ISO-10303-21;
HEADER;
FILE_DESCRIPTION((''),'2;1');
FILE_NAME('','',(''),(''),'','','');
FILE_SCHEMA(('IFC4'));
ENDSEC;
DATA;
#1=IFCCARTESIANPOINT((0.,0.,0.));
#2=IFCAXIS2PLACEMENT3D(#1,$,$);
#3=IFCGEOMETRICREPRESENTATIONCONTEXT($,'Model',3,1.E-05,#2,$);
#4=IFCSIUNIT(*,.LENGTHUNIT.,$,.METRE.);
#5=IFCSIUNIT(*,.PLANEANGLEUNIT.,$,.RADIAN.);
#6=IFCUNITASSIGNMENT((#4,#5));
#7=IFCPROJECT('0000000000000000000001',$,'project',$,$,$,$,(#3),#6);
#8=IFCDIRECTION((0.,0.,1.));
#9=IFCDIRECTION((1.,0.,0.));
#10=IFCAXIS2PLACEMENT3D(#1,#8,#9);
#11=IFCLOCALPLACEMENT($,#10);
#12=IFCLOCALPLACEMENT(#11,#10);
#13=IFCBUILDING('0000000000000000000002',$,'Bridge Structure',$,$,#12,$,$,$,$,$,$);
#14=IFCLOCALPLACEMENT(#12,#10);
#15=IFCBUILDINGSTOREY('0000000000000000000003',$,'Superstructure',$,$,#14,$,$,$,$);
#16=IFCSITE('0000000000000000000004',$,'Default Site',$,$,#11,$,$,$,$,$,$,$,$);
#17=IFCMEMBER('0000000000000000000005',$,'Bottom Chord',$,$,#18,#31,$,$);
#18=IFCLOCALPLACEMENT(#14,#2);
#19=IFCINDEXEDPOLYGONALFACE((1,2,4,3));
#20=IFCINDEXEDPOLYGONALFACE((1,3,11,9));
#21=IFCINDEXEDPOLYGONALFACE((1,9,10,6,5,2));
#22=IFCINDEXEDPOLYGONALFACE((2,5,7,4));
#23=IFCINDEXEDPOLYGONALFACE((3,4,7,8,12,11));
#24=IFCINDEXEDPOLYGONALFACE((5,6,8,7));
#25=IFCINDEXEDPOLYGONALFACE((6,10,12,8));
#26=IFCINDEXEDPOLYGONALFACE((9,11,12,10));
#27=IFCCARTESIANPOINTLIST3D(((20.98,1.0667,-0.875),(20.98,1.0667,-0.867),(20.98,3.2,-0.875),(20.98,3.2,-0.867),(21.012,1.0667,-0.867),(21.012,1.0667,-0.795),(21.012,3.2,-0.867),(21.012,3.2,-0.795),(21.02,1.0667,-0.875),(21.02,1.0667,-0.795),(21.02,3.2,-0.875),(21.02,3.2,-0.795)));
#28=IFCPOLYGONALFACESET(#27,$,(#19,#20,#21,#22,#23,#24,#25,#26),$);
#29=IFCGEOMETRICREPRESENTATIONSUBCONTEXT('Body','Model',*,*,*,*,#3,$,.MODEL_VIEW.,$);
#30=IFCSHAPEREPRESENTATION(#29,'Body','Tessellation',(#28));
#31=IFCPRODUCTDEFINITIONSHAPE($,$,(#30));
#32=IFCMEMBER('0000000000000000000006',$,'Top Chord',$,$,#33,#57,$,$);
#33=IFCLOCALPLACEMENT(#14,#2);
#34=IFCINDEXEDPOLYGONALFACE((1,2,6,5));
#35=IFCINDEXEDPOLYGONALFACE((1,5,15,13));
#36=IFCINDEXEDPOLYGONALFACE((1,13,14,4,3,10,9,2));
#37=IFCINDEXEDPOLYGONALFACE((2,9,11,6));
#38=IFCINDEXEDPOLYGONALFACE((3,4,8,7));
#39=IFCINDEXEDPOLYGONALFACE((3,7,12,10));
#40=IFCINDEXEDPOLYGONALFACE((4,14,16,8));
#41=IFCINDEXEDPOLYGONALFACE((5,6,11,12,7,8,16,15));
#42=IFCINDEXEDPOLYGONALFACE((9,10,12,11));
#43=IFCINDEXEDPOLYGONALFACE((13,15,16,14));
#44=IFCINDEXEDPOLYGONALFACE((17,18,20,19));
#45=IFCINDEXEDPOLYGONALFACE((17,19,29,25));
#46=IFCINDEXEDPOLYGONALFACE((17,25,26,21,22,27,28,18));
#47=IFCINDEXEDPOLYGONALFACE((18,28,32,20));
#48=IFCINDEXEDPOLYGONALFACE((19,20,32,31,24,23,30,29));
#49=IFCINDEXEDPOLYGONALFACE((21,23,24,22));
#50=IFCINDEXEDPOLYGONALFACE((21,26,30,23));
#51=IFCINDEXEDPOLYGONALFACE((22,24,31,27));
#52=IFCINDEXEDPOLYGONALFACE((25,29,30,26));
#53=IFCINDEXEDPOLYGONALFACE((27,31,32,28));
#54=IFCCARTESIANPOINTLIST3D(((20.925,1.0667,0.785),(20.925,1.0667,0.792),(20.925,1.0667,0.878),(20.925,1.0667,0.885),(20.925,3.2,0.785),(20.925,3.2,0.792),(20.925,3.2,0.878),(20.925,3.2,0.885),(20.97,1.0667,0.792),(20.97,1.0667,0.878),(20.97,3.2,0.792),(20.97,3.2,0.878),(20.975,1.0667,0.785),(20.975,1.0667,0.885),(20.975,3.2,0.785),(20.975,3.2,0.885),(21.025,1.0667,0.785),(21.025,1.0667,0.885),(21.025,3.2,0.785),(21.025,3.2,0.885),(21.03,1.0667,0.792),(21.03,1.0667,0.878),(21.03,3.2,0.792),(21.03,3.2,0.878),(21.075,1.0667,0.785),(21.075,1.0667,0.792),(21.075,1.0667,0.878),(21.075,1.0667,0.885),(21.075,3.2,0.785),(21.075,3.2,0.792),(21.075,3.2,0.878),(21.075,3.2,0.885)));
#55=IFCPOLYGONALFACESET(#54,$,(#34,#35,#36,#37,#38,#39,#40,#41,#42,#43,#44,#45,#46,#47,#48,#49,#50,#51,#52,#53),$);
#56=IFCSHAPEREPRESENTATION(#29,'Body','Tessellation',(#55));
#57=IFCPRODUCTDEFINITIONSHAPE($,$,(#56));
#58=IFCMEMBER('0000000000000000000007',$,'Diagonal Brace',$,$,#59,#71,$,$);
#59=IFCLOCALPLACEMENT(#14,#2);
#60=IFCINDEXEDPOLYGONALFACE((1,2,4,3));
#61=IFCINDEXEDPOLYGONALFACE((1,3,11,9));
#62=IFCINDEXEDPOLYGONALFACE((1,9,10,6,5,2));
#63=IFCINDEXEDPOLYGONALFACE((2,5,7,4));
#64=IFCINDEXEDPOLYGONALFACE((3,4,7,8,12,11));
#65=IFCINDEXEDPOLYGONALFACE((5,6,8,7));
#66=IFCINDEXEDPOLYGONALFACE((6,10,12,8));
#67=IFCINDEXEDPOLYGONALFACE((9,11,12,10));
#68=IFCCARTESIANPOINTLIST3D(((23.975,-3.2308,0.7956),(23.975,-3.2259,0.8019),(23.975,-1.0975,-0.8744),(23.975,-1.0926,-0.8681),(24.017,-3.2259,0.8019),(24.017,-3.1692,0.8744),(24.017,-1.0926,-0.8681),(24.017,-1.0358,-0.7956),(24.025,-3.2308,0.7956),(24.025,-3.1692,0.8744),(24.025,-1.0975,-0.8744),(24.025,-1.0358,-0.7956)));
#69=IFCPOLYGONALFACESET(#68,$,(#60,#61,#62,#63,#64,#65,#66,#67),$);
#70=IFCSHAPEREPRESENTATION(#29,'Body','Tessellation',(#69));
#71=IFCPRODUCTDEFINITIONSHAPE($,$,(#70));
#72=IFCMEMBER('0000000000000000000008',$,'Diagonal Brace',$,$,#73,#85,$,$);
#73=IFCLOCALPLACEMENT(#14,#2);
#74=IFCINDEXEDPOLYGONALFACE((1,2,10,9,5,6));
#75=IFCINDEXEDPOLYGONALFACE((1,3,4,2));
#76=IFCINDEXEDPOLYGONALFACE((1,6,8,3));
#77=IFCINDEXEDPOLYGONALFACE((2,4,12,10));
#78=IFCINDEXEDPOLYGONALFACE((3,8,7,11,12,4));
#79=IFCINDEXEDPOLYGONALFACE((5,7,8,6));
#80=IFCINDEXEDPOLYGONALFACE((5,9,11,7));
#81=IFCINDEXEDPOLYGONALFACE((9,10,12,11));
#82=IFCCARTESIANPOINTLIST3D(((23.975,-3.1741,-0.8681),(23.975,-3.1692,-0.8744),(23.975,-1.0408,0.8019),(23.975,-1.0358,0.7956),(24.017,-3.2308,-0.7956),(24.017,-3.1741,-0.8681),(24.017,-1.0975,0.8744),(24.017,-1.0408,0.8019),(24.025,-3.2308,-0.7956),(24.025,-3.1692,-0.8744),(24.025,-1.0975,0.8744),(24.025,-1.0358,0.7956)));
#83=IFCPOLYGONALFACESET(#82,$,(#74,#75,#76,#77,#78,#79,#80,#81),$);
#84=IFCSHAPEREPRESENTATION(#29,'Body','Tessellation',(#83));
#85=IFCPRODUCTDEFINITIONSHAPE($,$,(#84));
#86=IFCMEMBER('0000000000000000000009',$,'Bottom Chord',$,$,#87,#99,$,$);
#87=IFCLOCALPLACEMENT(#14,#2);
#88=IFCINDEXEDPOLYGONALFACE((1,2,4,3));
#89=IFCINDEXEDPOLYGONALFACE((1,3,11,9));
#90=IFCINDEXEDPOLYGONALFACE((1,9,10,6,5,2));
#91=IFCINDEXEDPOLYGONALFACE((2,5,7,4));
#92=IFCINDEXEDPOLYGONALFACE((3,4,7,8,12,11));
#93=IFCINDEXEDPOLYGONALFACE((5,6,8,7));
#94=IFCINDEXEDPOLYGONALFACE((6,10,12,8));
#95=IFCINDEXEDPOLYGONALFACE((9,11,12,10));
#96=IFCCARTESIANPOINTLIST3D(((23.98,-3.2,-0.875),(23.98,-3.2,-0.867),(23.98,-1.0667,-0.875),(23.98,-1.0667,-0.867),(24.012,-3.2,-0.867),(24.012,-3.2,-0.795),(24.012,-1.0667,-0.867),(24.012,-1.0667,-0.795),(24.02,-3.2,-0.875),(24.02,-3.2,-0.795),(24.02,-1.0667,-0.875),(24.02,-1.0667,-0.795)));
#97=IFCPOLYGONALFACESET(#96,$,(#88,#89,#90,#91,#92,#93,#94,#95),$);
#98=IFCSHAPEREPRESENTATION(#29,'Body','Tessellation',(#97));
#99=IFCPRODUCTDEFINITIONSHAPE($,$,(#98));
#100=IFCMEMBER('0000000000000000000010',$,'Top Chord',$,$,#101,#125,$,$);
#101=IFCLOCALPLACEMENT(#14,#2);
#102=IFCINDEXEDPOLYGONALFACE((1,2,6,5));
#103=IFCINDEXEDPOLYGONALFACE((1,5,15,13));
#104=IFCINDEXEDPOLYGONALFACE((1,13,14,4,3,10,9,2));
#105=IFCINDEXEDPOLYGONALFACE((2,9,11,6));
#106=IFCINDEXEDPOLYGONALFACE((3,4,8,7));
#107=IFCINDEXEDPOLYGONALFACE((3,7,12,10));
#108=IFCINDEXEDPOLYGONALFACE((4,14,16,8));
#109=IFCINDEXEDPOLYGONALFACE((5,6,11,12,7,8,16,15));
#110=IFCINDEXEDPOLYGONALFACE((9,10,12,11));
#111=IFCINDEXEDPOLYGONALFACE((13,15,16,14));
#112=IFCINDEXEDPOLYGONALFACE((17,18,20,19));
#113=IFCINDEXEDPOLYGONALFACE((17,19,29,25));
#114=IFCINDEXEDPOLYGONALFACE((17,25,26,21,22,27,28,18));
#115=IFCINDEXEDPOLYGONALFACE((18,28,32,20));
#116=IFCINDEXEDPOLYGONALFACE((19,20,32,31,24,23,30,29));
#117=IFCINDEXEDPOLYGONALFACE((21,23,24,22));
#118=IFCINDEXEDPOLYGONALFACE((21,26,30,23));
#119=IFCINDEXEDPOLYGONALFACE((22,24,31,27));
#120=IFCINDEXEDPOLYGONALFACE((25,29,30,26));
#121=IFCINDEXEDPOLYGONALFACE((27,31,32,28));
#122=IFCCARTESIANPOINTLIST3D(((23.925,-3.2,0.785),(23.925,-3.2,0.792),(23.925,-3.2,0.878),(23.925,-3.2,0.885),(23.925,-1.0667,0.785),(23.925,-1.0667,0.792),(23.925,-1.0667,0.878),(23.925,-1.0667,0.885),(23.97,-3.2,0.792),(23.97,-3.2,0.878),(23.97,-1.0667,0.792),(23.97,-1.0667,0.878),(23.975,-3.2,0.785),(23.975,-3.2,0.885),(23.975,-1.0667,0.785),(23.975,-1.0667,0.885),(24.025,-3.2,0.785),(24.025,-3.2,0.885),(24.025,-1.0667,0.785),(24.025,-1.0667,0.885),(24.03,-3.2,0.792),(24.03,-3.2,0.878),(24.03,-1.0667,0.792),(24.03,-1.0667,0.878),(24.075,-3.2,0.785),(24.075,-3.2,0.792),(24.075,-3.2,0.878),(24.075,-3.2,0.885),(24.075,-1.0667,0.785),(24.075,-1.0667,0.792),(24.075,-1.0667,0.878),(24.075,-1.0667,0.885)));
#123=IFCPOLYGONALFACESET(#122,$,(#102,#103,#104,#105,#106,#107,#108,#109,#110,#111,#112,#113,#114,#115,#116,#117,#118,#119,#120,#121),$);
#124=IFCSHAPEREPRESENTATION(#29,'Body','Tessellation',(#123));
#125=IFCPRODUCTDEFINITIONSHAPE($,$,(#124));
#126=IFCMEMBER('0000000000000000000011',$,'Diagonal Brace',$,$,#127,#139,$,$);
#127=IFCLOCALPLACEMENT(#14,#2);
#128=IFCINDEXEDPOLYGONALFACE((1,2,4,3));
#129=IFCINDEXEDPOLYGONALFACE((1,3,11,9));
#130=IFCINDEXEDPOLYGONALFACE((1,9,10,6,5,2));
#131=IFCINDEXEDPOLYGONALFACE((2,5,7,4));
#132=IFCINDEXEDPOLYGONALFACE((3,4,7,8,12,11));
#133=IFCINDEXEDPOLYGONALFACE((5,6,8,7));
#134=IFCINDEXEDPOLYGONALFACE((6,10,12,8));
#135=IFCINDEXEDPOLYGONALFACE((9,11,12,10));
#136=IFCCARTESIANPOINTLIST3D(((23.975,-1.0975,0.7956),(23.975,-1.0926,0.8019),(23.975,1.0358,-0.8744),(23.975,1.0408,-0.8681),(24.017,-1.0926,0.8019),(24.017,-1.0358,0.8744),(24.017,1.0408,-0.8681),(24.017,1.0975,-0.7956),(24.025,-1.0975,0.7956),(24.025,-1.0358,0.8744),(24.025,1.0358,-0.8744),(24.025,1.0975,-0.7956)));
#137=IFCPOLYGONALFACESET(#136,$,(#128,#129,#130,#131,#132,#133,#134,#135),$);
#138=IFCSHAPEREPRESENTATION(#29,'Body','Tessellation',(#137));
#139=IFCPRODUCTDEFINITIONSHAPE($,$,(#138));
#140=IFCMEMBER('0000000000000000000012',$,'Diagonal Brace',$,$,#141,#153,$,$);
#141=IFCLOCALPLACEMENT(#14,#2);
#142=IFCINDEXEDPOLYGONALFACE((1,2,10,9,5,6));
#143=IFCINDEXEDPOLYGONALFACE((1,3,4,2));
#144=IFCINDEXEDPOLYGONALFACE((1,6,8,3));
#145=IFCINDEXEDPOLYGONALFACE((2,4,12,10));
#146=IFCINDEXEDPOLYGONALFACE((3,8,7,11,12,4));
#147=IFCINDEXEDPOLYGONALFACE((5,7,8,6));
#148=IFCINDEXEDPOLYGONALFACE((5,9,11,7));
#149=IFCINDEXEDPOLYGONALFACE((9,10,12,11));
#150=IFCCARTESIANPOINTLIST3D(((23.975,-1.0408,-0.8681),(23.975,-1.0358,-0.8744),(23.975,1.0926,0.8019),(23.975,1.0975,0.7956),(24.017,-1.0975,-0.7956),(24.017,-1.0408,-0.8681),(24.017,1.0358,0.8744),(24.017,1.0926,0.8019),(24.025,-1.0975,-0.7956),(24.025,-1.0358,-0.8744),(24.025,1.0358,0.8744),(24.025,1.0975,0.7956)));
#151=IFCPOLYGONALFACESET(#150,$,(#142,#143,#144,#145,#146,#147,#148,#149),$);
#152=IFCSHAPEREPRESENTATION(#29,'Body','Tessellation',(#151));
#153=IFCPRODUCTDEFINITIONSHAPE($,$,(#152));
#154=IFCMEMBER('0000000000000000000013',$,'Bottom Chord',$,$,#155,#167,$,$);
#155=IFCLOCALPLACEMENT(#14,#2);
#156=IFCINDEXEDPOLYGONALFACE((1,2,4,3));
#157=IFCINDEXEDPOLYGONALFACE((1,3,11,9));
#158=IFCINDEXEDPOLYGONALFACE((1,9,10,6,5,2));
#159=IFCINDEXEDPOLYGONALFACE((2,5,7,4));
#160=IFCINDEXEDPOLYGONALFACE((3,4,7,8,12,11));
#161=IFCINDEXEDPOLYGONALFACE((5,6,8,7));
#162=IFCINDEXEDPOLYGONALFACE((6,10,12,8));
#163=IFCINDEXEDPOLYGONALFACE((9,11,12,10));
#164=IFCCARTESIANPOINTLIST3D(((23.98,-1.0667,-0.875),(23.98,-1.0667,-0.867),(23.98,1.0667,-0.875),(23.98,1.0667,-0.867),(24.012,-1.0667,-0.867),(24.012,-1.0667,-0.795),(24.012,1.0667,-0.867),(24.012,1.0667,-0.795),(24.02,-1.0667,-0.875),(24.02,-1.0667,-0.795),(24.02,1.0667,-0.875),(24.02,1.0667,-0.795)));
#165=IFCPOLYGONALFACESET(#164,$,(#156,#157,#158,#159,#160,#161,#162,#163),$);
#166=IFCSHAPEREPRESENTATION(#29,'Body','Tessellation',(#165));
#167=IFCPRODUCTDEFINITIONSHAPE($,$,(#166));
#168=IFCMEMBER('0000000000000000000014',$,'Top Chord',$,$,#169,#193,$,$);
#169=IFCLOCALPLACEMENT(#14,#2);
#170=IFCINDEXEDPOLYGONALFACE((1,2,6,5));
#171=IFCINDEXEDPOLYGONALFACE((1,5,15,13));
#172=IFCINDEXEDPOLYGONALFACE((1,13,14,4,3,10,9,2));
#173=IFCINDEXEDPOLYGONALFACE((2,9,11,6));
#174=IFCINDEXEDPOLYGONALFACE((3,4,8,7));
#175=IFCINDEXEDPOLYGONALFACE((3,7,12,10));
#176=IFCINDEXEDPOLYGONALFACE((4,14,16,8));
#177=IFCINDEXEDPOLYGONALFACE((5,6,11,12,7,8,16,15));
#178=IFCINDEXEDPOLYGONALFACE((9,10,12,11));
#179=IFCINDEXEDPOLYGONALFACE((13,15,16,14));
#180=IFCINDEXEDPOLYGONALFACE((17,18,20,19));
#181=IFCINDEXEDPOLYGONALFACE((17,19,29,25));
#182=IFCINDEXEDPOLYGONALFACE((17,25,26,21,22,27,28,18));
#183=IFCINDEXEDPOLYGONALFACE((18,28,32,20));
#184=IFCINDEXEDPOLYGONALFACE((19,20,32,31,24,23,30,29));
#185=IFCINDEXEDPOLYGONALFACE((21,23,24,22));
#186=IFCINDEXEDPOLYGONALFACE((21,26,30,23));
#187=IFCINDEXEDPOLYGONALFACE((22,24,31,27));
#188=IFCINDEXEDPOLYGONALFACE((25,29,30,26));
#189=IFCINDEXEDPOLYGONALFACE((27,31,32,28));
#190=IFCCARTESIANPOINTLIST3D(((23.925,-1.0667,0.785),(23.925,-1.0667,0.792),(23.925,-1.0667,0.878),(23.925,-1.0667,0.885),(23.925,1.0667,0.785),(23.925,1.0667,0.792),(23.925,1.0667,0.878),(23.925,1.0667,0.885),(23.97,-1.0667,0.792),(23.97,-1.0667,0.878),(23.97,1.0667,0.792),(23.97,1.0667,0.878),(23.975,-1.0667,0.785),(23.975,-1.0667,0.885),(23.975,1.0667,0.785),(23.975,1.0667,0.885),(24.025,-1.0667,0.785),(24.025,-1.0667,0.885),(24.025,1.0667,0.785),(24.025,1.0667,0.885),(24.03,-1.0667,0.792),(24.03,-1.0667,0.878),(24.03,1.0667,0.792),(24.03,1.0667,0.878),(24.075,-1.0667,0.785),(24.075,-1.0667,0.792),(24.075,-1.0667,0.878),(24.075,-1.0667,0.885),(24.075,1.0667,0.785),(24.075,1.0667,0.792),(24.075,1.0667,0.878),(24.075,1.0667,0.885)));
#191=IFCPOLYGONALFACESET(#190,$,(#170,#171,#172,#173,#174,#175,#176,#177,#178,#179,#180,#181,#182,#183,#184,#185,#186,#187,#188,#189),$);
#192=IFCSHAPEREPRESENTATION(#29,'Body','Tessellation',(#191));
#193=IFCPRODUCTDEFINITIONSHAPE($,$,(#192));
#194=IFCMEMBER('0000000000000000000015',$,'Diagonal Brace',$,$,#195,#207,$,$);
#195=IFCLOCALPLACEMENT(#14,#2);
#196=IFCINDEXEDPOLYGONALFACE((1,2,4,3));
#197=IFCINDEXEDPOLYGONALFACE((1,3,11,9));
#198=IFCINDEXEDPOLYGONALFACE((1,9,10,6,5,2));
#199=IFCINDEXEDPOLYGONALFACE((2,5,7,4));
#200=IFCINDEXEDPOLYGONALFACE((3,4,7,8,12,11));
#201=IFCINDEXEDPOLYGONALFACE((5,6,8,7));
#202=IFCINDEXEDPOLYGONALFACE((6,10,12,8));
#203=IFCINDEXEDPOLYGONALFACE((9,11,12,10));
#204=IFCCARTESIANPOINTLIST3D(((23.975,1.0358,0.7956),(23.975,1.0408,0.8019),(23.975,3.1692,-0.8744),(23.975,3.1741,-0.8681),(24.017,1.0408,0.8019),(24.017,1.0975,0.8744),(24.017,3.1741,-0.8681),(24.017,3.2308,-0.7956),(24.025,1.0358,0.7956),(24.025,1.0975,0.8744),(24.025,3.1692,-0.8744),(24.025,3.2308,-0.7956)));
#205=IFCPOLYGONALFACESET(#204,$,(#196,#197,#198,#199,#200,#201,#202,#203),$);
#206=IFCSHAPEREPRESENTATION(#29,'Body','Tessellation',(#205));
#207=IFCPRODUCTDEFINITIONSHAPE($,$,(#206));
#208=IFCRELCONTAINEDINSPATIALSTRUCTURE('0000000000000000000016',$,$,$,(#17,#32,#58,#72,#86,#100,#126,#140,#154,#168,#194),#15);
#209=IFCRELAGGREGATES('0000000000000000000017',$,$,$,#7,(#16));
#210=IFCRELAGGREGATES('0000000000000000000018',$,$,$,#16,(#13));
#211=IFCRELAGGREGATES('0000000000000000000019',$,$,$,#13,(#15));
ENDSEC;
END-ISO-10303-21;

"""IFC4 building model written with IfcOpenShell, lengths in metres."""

from ifc_helpers import new_model, si_unit, frame, origin, origin_with_axes, origin_2d_with_axis, place, context, subcontext, project, spatial, polyline, l_section, outline, composite_profile, extrude, element, save


model = new_model("IFC4")

# Units and contexts
model_context = context("Model", 3, precision=1e-05, world=origin())
body_context = subcontext(model_context, "Body", "Model", "MODEL_VIEW")
ifc_project = project(units=[si_unit("LENGTHUNIT", "METRE"), si_unit("PLANEANGLEUNIT", "RADIAN")], contexts=[model_context])

# Site, building, storey
site_placement = place(None, origin_with_axes())
site = spatial("IfcSite", under=ifc_project, at=site_placement, Name="Default Site")
building_placement = place(site_placement, origin_with_axes())
building = spatial("IfcBuilding", under=site, at=building_placement, Name="Bridge Structure")
storey_placement = place(building_placement, origin_with_axes())
storey = spatial("IfcBuildingStorey", under=building, at=storey_placement, Name="Superstructure")

# Members
member_1_placement = place(storey_placement, frame((21.0, 1.0667, -0.835), z_axis=(0.0, 1.0, 0.0), x_axis=(-1.0, 0.0, 0.0)))
element("IfcMember", 1, at=member_1_placement, inside=storey, Name="Bottom Chord", context=body_context, shape_type="SweptSolid", body=[
    extrude(l_section(Depth=0.08, Width=0.04, Thickness=0.008, at=origin_2d_with_axis()), origin_with_axes(), (0.0, 0.0, 1.0), 2.1333),
])
member_2_placement = place(storey_placement, frame((21.0, 1.0667, 0.835), z_axis=(0.0, 1.0, 0.0), x_axis=(-1.0, 0.0, 0.0)))
element("IfcMember", 2, at=member_2_placement, inside=storey, Name="Top Chord", context=body_context, shape_type="SweptSolid", body=[
    extrude(composite_profile([outline(polyline([(-0.025, -0.05), (-0.025, 0.05), (-0.075, 0.05), (-0.075, 0.043), (-0.03, 0.043), (-0.03, -0.043), (-0.075, -0.043), (-0.075, -0.05), (-0.025, -0.05)])), outline(polyline([(0.025, -0.05), (0.075, -0.05), (0.075, -0.043), (0.03, -0.043), (0.03, 0.043), (0.075, 0.043), (0.075, 0.05), (0.025, 0.05), (0.025, -0.05)]))]), origin_with_axes(), (0.0, 0.0, 1.0), 2.1333),
])
for number, where, z_axis, x_axis, name in (
    (3, (24.0, -3.2, 0.835), (0.0, 0.787427, -0.616408), (-1.0, 0.0, 0.0), "Diagonal Brace"),
    (4, (24.0, -3.2, -0.835), (0.0, 0.787427, 0.616408), (-1.0, 0.0, 0.0), "Diagonal Brace"),
):
    element("IfcMember", number, at=place(storey_placement, frame(where, z_axis=z_axis, x_axis=x_axis)), inside=storey, Name=name, context=body_context, shape_type="SweptSolid", body=[
        extrude(l_section(Depth=0.1, Width=0.05, Thickness=0.008, at=origin_2d_with_axis()), origin_with_axes(), (0.0, 0.0, 1.0), 2.7092),
    ])
member_3_placement = place(storey_placement, frame((24.0, -3.2, -0.835), z_axis=(0.0, 1.0, 0.0), x_axis=(-1.0, 0.0, 0.0)))
element("IfcMember", 5, at=member_3_placement, inside=storey, Name="Bottom Chord", context=body_context, shape_type="SweptSolid", body=[
    extrude(l_section(Depth=0.08, Width=0.04, Thickness=0.008, at=origin_2d_with_axis()), origin_with_axes(), (0.0, 0.0, 1.0), 2.1333),
])
member_4_placement = place(storey_placement, frame((24.0, -3.2, 0.835), z_axis=(0.0, 1.0, 0.0), x_axis=(-1.0, 0.0, 0.0)))
element("IfcMember", 6, at=member_4_placement, inside=storey, Name="Top Chord", context=body_context, shape_type="SweptSolid", body=[
    extrude(composite_profile([outline(polyline([(-0.025, -0.05), (-0.025, 0.05), (-0.075, 0.05), (-0.075, 0.043), (-0.03, 0.043), (-0.03, -0.043), (-0.075, -0.043), (-0.075, -0.05), (-0.025, -0.05)])), outline(polyline([(0.025, -0.05), (0.075, -0.05), (0.075, -0.043), (0.03, -0.043), (0.03, 0.043), (0.075, 0.043), (0.075, 0.05), (0.025, 0.05), (0.025, -0.05)]))]), origin_with_axes(), (0.0, 0.0, 1.0), 2.1333),
])
for number, where, z_axis, x_axis, name in (
    (7, (24.0, -1.0667, 0.835), (0.0, 0.787427, -0.616408), (-1.0, 0.0, 0.0), "Diagonal Brace"),
    (8, (24.0, -1.0667, -0.835), (0.0, 0.787427, 0.616408), (-1.0, 0.0, 0.0), "Diagonal Brace"),
):
    element("IfcMember", number, at=place(storey_placement, frame(where, z_axis=z_axis, x_axis=x_axis)), inside=storey, Name=name, context=body_context, shape_type="SweptSolid", body=[
        extrude(l_section(Depth=0.1, Width=0.05, Thickness=0.008, at=origin_2d_with_axis()), origin_with_axes(), (0.0, 0.0, 1.0), 2.7092),
    ])
member_5_placement = place(storey_placement, frame((24.0, -1.0667, -0.835), z_axis=(0.0, 1.0, 0.0), x_axis=(-1.0, 0.0, 0.0)))
element("IfcMember", 9, at=member_5_placement, inside=storey, Name="Bottom Chord", context=body_context, shape_type="SweptSolid", body=[
    extrude(l_section(Depth=0.08, Width=0.04, Thickness=0.008, at=origin_2d_with_axis()), origin_with_axes(), (0.0, 0.0, 1.0), 2.1333),
])
member_6_placement = place(storey_placement, frame((24.0, -1.0667, 0.835), z_axis=(0.0, 1.0, 0.0), x_axis=(-1.0, 0.0, 0.0)))
element("IfcMember", 10, at=member_6_placement, inside=storey, Name="Top Chord", context=body_context, shape_type="SweptSolid", body=[
    extrude(composite_profile([outline(polyline([(-0.025, -0.05), (-0.025, 0.05), (-0.075, 0.05), (-0.075, 0.043), (-0.03, 0.043), (-0.03, -0.043), (-0.075, -0.043), (-0.075, -0.05), (-0.025, -0.05)])), outline(polyline([(0.025, -0.05), (0.075, -0.05), (0.075, -0.043), (0.03, -0.043), (0.03, 0.043), (0.075, 0.043), (0.075, 0.05), (0.025, 0.05), (0.025, -0.05)]))]), origin_with_axes(), (0.0, 0.0, 1.0), 2.1333),
])
member_7_placement = place(storey_placement, frame((24.0, 1.0667, 0.835), z_axis=(0.0, 0.787427, -0.616408), x_axis=(-1.0, 0.0, 0.0)))
element("IfcMember", 11, at=member_7_placement, inside=storey, Name="Diagonal Brace", context=body_context, shape_type="SweptSolid", body=[
    extrude(l_section(Depth=0.1, Width=0.05, Thickness=0.008, at=origin_2d_with_axis()), origin_with_axes(), (0.0, 0.0, 1.0), 2.7092),
])

save(model, "model.ifc")
